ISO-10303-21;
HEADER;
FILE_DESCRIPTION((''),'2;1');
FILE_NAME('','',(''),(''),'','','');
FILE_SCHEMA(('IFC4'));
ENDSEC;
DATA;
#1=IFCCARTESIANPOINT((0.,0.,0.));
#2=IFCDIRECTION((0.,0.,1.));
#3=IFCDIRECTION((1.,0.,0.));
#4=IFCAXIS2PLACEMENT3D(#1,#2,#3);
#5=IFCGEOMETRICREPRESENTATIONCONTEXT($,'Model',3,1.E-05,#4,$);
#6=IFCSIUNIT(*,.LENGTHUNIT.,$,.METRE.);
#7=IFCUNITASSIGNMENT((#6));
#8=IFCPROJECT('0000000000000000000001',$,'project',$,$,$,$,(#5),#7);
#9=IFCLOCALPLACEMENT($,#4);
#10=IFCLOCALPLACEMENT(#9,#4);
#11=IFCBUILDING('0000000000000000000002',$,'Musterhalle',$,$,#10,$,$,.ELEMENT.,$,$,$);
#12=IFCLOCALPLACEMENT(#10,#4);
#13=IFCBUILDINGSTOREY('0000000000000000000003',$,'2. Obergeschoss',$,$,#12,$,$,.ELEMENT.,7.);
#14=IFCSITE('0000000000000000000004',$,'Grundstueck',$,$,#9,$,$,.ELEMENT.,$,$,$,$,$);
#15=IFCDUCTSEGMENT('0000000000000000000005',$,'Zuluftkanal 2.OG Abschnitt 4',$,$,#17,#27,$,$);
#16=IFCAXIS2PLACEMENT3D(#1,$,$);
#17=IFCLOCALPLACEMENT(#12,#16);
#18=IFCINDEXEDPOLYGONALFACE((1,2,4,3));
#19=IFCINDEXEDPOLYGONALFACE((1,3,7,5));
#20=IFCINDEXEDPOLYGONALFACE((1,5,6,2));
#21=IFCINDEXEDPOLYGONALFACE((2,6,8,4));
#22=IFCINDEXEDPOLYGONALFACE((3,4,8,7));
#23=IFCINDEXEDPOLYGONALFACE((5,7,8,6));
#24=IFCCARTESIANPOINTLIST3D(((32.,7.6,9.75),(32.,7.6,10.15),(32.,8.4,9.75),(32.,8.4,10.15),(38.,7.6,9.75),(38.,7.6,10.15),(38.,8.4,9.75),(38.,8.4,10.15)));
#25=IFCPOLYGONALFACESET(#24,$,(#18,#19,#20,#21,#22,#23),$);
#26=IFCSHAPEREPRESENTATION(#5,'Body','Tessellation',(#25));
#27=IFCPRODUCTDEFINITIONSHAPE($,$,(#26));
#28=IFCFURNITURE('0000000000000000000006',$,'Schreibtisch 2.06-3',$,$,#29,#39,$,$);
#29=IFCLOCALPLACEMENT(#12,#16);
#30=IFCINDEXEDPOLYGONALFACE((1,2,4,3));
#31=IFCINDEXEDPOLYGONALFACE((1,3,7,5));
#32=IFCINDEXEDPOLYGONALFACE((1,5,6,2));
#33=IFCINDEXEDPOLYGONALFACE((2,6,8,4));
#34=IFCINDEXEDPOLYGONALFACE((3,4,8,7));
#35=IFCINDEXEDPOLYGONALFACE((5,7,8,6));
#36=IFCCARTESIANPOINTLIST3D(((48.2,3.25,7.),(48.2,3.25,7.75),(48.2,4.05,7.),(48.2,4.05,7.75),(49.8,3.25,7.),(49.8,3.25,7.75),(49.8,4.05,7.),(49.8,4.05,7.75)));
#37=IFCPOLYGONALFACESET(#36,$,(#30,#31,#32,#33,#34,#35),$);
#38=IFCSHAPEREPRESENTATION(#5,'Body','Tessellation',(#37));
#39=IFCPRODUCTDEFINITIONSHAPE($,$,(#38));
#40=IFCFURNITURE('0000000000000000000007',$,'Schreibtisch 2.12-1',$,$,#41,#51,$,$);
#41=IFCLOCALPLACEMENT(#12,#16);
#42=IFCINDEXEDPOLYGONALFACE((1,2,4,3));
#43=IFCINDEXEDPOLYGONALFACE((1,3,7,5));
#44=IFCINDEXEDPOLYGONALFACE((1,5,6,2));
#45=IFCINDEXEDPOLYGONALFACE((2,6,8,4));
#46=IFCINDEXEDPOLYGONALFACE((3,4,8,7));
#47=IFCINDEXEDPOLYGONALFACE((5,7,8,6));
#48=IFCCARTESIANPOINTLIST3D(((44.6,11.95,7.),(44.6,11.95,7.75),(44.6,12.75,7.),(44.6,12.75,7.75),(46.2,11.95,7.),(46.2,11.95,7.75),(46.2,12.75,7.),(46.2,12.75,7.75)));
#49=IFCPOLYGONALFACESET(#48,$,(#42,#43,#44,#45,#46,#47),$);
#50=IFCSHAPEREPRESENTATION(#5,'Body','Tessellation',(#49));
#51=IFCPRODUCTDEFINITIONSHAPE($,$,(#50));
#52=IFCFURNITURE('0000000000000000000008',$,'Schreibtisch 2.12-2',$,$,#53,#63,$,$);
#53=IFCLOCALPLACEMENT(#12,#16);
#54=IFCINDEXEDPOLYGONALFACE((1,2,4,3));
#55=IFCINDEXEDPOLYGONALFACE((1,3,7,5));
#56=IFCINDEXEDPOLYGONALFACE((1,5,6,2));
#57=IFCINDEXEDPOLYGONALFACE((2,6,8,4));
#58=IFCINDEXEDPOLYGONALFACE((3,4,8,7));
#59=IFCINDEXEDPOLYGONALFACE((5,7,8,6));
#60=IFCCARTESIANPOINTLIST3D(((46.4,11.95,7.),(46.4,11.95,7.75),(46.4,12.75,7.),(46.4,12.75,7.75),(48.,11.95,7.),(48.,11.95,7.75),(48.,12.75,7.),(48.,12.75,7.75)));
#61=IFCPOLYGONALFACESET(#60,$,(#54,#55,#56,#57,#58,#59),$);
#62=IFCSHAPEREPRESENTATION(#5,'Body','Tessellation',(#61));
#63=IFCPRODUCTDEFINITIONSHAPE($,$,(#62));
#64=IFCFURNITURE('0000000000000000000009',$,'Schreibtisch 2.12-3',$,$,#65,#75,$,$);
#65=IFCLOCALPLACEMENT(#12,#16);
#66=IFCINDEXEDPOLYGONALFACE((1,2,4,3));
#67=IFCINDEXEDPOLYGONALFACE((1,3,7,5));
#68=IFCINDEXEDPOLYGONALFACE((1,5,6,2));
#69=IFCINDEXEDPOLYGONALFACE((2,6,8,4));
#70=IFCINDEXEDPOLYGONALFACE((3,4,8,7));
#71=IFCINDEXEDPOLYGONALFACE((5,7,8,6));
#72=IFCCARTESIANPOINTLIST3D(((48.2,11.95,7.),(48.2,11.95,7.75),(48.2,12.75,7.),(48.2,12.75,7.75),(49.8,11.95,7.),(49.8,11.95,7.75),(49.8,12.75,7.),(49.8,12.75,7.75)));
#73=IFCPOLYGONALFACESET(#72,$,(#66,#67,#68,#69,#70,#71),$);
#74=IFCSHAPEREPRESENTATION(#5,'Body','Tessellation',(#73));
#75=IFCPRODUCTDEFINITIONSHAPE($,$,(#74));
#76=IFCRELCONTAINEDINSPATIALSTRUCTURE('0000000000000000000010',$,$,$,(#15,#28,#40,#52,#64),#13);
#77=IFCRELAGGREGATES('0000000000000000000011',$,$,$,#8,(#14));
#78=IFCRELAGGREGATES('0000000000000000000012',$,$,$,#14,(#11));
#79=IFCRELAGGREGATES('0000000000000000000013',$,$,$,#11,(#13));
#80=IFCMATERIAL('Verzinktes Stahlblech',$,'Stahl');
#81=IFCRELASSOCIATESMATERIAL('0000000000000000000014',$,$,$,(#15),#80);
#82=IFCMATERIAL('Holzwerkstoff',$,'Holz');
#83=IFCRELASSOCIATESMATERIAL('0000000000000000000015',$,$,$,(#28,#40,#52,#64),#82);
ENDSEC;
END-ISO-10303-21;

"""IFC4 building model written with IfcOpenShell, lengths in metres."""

from ifc_helpers import new_model, si_unit, frame, origin_with_axes, origin_2d, place, context, project, spatial, rectangle, extrude, material, element, save


model = new_model("IFC4")

# Units and contexts
model_context = context("Model", 3, precision=1e-05, world=origin_with_axes())
ifc_project = project(units=[si_unit("LENGTHUNIT", "METRE")], contexts=[model_context])

# Site, building, storey
site_placement = place(None, origin_with_axes())
site = spatial("IfcSite", under=ifc_project, at=site_placement, Name="Grundstueck", CompositionType="ELEMENT")
building_placement = place(site_placement, origin_with_axes())
building = spatial("IfcBuilding", under=site, at=building_placement, Name="Musterhalle", CompositionType="ELEMENT")
storey_placement = place(building_placement, origin_with_axes())
storey = spatial("IfcBuildingStorey", under=building, at=storey_placement, Name="2. Obergeschoss", CompositionType="ELEMENT", Elevation=7.0)

# Shared definitions
placement = place(storey_placement, origin_with_axes())

# Shared definitions
ifc_material_1 = material(Name="Holzwerkstoff", Category="Holz")

# Shared definitions
ifc_material_2 = material(Name="Verzinktes Stahlblech", Category="Stahl")

# Duct segment
element("IfcDuctSegment", 1, at=placement, inside=storey, material=ifc_material_2, Name="Zuluftkanal 2.OG Abschnitt 4", context=model_context, shape_type="SweptSolid", body=[
    extrude(rectangle(XDim=6.0, YDim=0.8, at=origin_2d()), frame((35.0, 8.0, 9.75), z_axis=(0.0, 0.0, 1.0), x_axis=(1.0, 0.0, 0.0)), (0.0, 0.0, 1.0), 0.4),
])

# Furniture
element("IfcFurniture", 2, at=placement, inside=storey, material=ifc_material_1, Name="Schreibtisch 2.06-3", context=model_context, shape_type="SweptSolid", body=[
    extrude(rectangle(XDim=1.6, YDim=0.8, at=origin_2d()), frame((49.0, 3.65, 7.0), z_axis=(0.0, 0.0, 1.0), x_axis=(1.0, 0.0, 0.0)), (0.0, 0.0, 1.0), 0.75),
])
element("IfcFurniture", 3, at=placement, inside=storey, material=ifc_material_1, Name="Schreibtisch 2.12-1", context=model_context, shape_type="SweptSolid", body=[
    extrude(rectangle(XDim=1.6, YDim=0.8, at=origin_2d()), frame((45.4, 12.35, 7.0), z_axis=(0.0, 0.0, 1.0), x_axis=(1.0, 0.0, 0.0)), (0.0, 0.0, 1.0), 0.75),
])
element("IfcFurniture", 4, at=placement, inside=storey, material=ifc_material_1, Name="Schreibtisch 2.12-2", context=model_context, shape_type="SweptSolid", body=[
    extrude(rectangle(XDim=1.6, YDim=0.8, at=origin_2d()), frame((47.2, 12.35, 7.0), z_axis=(0.0, 0.0, 1.0), x_axis=(1.0, 0.0, 0.0)), (0.0, 0.0, 1.0), 0.75),
])
element("IfcFurniture", 5, at=placement, inside=storey, material=ifc_material_1, Name="Schreibtisch 2.12-3", context=model_context, shape_type="SweptSolid", body=[
    extrude(rectangle(XDim=1.6, YDim=0.8, at=origin_2d()), frame((49.0, 12.35, 7.0), z_axis=(0.0, 0.0, 1.0), x_axis=(1.0, 0.0, 0.0)), (0.0, 0.0, 1.0), 0.75),
])

save(model, "model.ifc")
